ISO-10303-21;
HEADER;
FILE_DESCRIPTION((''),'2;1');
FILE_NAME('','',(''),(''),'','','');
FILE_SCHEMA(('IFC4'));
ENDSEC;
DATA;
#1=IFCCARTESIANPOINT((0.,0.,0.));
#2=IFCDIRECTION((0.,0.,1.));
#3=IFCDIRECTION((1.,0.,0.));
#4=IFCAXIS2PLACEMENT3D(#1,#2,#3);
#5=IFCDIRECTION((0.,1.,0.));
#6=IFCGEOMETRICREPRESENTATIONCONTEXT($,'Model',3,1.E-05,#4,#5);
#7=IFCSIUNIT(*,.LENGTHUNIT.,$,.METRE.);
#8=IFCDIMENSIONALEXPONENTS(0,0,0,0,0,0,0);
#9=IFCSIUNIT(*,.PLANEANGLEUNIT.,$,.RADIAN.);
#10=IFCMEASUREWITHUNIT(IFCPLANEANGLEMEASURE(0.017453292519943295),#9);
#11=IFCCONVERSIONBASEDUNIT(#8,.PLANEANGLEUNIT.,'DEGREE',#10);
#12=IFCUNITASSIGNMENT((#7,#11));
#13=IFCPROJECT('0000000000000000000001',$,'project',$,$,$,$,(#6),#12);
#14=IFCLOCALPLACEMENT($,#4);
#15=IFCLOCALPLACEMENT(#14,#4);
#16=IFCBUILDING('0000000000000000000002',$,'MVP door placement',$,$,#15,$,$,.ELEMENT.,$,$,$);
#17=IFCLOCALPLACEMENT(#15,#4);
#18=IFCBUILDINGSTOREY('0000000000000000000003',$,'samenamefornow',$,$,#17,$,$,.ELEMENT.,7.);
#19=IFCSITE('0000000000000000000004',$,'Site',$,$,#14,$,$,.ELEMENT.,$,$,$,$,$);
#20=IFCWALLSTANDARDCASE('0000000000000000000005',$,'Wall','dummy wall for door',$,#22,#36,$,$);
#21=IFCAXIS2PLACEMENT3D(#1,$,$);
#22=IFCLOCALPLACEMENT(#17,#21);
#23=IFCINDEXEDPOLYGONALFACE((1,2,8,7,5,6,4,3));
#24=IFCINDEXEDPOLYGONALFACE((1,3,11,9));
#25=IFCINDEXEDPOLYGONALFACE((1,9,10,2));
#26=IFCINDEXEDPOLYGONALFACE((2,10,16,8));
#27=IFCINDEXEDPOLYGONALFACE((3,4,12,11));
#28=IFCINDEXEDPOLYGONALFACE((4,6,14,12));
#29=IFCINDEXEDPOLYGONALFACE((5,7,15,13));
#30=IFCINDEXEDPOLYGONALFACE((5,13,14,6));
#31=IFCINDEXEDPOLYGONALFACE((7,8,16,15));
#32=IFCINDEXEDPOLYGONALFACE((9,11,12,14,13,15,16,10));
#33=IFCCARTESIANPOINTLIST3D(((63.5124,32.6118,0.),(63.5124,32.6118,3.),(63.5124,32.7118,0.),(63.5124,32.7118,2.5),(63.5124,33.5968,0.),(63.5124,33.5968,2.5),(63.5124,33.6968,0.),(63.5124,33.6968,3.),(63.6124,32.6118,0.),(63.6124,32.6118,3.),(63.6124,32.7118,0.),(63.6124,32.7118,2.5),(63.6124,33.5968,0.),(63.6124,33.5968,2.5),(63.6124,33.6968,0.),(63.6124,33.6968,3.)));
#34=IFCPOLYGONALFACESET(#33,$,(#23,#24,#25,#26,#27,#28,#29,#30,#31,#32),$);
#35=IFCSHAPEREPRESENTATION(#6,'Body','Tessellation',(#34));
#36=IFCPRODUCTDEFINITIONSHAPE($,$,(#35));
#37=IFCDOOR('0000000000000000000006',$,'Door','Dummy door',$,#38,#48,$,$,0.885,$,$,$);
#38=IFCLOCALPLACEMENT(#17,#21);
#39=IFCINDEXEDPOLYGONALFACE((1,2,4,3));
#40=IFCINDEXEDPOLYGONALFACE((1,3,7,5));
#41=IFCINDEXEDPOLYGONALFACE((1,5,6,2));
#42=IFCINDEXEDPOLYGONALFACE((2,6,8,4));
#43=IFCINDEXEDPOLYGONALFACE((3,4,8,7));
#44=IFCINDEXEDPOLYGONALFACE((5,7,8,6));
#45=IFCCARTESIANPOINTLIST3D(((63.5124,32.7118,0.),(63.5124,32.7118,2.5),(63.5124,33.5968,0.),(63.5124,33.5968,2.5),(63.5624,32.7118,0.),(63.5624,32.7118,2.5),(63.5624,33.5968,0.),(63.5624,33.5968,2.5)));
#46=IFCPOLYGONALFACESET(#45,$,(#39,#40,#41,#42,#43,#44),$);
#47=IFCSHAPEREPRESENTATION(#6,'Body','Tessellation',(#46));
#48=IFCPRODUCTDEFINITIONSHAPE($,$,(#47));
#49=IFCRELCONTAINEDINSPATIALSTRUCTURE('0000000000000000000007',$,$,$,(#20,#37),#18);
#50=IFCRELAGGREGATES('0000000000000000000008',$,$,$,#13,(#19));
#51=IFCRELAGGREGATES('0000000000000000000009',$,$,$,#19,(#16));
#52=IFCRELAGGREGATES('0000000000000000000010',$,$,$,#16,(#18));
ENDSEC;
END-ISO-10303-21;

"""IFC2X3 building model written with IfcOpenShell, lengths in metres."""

from ifc_helpers import new_model, entity, si_unit, converted_unit, direction, origin_with_axes, place, context, project, spatial, polyline, outline, extrude, element, fill, save


model = new_model("IFC2X3")

# Units and contexts
model_context = context("Model", 3, precision=1e-05, world=origin_with_axes(), true_north=direction((0.0, 1.0, 0.0)))
ifc_project = project(units=[si_unit("LENGTHUNIT", "METRE"), converted_unit("PLANEANGLEUNIT", "DEGREE", entity("IfcPlaneAngleMeasure", 0.017453292519943295), si_unit("PLANEANGLEUNIT", "RADIAN"), dimensions=[0, 0, 0, 0, 0, 0, 0])], contexts=[model_context])

# Site, building, storey
site_placement = place(None, origin_with_axes())
site = spatial("IfcSite", under=ifc_project, at=site_placement, Name="Site", CompositionType="ELEMENT")
building_placement = place(site_placement, origin_with_axes())
building = spatial("IfcBuilding", under=site, at=building_placement, Name="MVP door placement", CompositionType="ELEMENT")
storey_placement = place(building_placement, origin_with_axes())
storey = spatial("IfcBuildingStorey", under=building, at=storey_placement, Name="samenamefornow", CompositionType="ELEMENT", Elevation=7.0)

# Wall, opening, door
wall_1_placement = place(storey_placement, origin_with_axes())
wall_1 = element("IfcWallStandardCase", 1, at=wall_1_placement, inside=storey, Name="Wall", Description="dummy wall for door", context=model_context, shape_type="SweptSolid", body=[
    extrude(outline(polyline([(63.5124, 32.6118, 0.0), (63.5124, 33.6968, 0.0), (63.6124, 33.6968, 0.0), (63.6124, 32.6118, 0.0), (63.5124, 32.6118, 0.0)])), origin_with_axes(), (0.0, 0.0, 1.0), 3.0),
])
opening_1_placement = place(wall_1_placement, origin_with_axes())
opening_1 = element("IfcOpeningElement", 2, at=opening_1_placement, cuts=wall_1, context=model_context, shape_type="SweptSolid", body=[
    extrude(outline(polyline([(63.5124, 32.7118, 0.0), (63.5124, 33.5968, 0.0), (63.6124, 33.5968, 0.0), (63.6124, 32.7118, 0.0), (63.5124, 32.7118, 0.0)])), origin_with_axes(), (0.0, 0.0, 1.0), 2.5),
])
door_1_placement = place(opening_1_placement, origin_with_axes())
door_1 = element("IfcDoor", 3, at=door_1_placement, inside=storey, Name="Door", Description="Dummy door", OverallWidth=0.885, context=model_context, shape_type="SweptSolid", body=[
    extrude(outline(polyline([(63.5124, 32.7118, 0.0), (63.5124, 33.5968, 0.0), (63.5624, 33.5968, 0.0), (63.5624, 32.7118, 0.0), (63.5124, 32.7118, 0.0)])), origin_with_axes(), (0.0, 0.0, 1.0), 2.5),
])
fill(opening_1, door_1)

save(model, "model.ifc")
